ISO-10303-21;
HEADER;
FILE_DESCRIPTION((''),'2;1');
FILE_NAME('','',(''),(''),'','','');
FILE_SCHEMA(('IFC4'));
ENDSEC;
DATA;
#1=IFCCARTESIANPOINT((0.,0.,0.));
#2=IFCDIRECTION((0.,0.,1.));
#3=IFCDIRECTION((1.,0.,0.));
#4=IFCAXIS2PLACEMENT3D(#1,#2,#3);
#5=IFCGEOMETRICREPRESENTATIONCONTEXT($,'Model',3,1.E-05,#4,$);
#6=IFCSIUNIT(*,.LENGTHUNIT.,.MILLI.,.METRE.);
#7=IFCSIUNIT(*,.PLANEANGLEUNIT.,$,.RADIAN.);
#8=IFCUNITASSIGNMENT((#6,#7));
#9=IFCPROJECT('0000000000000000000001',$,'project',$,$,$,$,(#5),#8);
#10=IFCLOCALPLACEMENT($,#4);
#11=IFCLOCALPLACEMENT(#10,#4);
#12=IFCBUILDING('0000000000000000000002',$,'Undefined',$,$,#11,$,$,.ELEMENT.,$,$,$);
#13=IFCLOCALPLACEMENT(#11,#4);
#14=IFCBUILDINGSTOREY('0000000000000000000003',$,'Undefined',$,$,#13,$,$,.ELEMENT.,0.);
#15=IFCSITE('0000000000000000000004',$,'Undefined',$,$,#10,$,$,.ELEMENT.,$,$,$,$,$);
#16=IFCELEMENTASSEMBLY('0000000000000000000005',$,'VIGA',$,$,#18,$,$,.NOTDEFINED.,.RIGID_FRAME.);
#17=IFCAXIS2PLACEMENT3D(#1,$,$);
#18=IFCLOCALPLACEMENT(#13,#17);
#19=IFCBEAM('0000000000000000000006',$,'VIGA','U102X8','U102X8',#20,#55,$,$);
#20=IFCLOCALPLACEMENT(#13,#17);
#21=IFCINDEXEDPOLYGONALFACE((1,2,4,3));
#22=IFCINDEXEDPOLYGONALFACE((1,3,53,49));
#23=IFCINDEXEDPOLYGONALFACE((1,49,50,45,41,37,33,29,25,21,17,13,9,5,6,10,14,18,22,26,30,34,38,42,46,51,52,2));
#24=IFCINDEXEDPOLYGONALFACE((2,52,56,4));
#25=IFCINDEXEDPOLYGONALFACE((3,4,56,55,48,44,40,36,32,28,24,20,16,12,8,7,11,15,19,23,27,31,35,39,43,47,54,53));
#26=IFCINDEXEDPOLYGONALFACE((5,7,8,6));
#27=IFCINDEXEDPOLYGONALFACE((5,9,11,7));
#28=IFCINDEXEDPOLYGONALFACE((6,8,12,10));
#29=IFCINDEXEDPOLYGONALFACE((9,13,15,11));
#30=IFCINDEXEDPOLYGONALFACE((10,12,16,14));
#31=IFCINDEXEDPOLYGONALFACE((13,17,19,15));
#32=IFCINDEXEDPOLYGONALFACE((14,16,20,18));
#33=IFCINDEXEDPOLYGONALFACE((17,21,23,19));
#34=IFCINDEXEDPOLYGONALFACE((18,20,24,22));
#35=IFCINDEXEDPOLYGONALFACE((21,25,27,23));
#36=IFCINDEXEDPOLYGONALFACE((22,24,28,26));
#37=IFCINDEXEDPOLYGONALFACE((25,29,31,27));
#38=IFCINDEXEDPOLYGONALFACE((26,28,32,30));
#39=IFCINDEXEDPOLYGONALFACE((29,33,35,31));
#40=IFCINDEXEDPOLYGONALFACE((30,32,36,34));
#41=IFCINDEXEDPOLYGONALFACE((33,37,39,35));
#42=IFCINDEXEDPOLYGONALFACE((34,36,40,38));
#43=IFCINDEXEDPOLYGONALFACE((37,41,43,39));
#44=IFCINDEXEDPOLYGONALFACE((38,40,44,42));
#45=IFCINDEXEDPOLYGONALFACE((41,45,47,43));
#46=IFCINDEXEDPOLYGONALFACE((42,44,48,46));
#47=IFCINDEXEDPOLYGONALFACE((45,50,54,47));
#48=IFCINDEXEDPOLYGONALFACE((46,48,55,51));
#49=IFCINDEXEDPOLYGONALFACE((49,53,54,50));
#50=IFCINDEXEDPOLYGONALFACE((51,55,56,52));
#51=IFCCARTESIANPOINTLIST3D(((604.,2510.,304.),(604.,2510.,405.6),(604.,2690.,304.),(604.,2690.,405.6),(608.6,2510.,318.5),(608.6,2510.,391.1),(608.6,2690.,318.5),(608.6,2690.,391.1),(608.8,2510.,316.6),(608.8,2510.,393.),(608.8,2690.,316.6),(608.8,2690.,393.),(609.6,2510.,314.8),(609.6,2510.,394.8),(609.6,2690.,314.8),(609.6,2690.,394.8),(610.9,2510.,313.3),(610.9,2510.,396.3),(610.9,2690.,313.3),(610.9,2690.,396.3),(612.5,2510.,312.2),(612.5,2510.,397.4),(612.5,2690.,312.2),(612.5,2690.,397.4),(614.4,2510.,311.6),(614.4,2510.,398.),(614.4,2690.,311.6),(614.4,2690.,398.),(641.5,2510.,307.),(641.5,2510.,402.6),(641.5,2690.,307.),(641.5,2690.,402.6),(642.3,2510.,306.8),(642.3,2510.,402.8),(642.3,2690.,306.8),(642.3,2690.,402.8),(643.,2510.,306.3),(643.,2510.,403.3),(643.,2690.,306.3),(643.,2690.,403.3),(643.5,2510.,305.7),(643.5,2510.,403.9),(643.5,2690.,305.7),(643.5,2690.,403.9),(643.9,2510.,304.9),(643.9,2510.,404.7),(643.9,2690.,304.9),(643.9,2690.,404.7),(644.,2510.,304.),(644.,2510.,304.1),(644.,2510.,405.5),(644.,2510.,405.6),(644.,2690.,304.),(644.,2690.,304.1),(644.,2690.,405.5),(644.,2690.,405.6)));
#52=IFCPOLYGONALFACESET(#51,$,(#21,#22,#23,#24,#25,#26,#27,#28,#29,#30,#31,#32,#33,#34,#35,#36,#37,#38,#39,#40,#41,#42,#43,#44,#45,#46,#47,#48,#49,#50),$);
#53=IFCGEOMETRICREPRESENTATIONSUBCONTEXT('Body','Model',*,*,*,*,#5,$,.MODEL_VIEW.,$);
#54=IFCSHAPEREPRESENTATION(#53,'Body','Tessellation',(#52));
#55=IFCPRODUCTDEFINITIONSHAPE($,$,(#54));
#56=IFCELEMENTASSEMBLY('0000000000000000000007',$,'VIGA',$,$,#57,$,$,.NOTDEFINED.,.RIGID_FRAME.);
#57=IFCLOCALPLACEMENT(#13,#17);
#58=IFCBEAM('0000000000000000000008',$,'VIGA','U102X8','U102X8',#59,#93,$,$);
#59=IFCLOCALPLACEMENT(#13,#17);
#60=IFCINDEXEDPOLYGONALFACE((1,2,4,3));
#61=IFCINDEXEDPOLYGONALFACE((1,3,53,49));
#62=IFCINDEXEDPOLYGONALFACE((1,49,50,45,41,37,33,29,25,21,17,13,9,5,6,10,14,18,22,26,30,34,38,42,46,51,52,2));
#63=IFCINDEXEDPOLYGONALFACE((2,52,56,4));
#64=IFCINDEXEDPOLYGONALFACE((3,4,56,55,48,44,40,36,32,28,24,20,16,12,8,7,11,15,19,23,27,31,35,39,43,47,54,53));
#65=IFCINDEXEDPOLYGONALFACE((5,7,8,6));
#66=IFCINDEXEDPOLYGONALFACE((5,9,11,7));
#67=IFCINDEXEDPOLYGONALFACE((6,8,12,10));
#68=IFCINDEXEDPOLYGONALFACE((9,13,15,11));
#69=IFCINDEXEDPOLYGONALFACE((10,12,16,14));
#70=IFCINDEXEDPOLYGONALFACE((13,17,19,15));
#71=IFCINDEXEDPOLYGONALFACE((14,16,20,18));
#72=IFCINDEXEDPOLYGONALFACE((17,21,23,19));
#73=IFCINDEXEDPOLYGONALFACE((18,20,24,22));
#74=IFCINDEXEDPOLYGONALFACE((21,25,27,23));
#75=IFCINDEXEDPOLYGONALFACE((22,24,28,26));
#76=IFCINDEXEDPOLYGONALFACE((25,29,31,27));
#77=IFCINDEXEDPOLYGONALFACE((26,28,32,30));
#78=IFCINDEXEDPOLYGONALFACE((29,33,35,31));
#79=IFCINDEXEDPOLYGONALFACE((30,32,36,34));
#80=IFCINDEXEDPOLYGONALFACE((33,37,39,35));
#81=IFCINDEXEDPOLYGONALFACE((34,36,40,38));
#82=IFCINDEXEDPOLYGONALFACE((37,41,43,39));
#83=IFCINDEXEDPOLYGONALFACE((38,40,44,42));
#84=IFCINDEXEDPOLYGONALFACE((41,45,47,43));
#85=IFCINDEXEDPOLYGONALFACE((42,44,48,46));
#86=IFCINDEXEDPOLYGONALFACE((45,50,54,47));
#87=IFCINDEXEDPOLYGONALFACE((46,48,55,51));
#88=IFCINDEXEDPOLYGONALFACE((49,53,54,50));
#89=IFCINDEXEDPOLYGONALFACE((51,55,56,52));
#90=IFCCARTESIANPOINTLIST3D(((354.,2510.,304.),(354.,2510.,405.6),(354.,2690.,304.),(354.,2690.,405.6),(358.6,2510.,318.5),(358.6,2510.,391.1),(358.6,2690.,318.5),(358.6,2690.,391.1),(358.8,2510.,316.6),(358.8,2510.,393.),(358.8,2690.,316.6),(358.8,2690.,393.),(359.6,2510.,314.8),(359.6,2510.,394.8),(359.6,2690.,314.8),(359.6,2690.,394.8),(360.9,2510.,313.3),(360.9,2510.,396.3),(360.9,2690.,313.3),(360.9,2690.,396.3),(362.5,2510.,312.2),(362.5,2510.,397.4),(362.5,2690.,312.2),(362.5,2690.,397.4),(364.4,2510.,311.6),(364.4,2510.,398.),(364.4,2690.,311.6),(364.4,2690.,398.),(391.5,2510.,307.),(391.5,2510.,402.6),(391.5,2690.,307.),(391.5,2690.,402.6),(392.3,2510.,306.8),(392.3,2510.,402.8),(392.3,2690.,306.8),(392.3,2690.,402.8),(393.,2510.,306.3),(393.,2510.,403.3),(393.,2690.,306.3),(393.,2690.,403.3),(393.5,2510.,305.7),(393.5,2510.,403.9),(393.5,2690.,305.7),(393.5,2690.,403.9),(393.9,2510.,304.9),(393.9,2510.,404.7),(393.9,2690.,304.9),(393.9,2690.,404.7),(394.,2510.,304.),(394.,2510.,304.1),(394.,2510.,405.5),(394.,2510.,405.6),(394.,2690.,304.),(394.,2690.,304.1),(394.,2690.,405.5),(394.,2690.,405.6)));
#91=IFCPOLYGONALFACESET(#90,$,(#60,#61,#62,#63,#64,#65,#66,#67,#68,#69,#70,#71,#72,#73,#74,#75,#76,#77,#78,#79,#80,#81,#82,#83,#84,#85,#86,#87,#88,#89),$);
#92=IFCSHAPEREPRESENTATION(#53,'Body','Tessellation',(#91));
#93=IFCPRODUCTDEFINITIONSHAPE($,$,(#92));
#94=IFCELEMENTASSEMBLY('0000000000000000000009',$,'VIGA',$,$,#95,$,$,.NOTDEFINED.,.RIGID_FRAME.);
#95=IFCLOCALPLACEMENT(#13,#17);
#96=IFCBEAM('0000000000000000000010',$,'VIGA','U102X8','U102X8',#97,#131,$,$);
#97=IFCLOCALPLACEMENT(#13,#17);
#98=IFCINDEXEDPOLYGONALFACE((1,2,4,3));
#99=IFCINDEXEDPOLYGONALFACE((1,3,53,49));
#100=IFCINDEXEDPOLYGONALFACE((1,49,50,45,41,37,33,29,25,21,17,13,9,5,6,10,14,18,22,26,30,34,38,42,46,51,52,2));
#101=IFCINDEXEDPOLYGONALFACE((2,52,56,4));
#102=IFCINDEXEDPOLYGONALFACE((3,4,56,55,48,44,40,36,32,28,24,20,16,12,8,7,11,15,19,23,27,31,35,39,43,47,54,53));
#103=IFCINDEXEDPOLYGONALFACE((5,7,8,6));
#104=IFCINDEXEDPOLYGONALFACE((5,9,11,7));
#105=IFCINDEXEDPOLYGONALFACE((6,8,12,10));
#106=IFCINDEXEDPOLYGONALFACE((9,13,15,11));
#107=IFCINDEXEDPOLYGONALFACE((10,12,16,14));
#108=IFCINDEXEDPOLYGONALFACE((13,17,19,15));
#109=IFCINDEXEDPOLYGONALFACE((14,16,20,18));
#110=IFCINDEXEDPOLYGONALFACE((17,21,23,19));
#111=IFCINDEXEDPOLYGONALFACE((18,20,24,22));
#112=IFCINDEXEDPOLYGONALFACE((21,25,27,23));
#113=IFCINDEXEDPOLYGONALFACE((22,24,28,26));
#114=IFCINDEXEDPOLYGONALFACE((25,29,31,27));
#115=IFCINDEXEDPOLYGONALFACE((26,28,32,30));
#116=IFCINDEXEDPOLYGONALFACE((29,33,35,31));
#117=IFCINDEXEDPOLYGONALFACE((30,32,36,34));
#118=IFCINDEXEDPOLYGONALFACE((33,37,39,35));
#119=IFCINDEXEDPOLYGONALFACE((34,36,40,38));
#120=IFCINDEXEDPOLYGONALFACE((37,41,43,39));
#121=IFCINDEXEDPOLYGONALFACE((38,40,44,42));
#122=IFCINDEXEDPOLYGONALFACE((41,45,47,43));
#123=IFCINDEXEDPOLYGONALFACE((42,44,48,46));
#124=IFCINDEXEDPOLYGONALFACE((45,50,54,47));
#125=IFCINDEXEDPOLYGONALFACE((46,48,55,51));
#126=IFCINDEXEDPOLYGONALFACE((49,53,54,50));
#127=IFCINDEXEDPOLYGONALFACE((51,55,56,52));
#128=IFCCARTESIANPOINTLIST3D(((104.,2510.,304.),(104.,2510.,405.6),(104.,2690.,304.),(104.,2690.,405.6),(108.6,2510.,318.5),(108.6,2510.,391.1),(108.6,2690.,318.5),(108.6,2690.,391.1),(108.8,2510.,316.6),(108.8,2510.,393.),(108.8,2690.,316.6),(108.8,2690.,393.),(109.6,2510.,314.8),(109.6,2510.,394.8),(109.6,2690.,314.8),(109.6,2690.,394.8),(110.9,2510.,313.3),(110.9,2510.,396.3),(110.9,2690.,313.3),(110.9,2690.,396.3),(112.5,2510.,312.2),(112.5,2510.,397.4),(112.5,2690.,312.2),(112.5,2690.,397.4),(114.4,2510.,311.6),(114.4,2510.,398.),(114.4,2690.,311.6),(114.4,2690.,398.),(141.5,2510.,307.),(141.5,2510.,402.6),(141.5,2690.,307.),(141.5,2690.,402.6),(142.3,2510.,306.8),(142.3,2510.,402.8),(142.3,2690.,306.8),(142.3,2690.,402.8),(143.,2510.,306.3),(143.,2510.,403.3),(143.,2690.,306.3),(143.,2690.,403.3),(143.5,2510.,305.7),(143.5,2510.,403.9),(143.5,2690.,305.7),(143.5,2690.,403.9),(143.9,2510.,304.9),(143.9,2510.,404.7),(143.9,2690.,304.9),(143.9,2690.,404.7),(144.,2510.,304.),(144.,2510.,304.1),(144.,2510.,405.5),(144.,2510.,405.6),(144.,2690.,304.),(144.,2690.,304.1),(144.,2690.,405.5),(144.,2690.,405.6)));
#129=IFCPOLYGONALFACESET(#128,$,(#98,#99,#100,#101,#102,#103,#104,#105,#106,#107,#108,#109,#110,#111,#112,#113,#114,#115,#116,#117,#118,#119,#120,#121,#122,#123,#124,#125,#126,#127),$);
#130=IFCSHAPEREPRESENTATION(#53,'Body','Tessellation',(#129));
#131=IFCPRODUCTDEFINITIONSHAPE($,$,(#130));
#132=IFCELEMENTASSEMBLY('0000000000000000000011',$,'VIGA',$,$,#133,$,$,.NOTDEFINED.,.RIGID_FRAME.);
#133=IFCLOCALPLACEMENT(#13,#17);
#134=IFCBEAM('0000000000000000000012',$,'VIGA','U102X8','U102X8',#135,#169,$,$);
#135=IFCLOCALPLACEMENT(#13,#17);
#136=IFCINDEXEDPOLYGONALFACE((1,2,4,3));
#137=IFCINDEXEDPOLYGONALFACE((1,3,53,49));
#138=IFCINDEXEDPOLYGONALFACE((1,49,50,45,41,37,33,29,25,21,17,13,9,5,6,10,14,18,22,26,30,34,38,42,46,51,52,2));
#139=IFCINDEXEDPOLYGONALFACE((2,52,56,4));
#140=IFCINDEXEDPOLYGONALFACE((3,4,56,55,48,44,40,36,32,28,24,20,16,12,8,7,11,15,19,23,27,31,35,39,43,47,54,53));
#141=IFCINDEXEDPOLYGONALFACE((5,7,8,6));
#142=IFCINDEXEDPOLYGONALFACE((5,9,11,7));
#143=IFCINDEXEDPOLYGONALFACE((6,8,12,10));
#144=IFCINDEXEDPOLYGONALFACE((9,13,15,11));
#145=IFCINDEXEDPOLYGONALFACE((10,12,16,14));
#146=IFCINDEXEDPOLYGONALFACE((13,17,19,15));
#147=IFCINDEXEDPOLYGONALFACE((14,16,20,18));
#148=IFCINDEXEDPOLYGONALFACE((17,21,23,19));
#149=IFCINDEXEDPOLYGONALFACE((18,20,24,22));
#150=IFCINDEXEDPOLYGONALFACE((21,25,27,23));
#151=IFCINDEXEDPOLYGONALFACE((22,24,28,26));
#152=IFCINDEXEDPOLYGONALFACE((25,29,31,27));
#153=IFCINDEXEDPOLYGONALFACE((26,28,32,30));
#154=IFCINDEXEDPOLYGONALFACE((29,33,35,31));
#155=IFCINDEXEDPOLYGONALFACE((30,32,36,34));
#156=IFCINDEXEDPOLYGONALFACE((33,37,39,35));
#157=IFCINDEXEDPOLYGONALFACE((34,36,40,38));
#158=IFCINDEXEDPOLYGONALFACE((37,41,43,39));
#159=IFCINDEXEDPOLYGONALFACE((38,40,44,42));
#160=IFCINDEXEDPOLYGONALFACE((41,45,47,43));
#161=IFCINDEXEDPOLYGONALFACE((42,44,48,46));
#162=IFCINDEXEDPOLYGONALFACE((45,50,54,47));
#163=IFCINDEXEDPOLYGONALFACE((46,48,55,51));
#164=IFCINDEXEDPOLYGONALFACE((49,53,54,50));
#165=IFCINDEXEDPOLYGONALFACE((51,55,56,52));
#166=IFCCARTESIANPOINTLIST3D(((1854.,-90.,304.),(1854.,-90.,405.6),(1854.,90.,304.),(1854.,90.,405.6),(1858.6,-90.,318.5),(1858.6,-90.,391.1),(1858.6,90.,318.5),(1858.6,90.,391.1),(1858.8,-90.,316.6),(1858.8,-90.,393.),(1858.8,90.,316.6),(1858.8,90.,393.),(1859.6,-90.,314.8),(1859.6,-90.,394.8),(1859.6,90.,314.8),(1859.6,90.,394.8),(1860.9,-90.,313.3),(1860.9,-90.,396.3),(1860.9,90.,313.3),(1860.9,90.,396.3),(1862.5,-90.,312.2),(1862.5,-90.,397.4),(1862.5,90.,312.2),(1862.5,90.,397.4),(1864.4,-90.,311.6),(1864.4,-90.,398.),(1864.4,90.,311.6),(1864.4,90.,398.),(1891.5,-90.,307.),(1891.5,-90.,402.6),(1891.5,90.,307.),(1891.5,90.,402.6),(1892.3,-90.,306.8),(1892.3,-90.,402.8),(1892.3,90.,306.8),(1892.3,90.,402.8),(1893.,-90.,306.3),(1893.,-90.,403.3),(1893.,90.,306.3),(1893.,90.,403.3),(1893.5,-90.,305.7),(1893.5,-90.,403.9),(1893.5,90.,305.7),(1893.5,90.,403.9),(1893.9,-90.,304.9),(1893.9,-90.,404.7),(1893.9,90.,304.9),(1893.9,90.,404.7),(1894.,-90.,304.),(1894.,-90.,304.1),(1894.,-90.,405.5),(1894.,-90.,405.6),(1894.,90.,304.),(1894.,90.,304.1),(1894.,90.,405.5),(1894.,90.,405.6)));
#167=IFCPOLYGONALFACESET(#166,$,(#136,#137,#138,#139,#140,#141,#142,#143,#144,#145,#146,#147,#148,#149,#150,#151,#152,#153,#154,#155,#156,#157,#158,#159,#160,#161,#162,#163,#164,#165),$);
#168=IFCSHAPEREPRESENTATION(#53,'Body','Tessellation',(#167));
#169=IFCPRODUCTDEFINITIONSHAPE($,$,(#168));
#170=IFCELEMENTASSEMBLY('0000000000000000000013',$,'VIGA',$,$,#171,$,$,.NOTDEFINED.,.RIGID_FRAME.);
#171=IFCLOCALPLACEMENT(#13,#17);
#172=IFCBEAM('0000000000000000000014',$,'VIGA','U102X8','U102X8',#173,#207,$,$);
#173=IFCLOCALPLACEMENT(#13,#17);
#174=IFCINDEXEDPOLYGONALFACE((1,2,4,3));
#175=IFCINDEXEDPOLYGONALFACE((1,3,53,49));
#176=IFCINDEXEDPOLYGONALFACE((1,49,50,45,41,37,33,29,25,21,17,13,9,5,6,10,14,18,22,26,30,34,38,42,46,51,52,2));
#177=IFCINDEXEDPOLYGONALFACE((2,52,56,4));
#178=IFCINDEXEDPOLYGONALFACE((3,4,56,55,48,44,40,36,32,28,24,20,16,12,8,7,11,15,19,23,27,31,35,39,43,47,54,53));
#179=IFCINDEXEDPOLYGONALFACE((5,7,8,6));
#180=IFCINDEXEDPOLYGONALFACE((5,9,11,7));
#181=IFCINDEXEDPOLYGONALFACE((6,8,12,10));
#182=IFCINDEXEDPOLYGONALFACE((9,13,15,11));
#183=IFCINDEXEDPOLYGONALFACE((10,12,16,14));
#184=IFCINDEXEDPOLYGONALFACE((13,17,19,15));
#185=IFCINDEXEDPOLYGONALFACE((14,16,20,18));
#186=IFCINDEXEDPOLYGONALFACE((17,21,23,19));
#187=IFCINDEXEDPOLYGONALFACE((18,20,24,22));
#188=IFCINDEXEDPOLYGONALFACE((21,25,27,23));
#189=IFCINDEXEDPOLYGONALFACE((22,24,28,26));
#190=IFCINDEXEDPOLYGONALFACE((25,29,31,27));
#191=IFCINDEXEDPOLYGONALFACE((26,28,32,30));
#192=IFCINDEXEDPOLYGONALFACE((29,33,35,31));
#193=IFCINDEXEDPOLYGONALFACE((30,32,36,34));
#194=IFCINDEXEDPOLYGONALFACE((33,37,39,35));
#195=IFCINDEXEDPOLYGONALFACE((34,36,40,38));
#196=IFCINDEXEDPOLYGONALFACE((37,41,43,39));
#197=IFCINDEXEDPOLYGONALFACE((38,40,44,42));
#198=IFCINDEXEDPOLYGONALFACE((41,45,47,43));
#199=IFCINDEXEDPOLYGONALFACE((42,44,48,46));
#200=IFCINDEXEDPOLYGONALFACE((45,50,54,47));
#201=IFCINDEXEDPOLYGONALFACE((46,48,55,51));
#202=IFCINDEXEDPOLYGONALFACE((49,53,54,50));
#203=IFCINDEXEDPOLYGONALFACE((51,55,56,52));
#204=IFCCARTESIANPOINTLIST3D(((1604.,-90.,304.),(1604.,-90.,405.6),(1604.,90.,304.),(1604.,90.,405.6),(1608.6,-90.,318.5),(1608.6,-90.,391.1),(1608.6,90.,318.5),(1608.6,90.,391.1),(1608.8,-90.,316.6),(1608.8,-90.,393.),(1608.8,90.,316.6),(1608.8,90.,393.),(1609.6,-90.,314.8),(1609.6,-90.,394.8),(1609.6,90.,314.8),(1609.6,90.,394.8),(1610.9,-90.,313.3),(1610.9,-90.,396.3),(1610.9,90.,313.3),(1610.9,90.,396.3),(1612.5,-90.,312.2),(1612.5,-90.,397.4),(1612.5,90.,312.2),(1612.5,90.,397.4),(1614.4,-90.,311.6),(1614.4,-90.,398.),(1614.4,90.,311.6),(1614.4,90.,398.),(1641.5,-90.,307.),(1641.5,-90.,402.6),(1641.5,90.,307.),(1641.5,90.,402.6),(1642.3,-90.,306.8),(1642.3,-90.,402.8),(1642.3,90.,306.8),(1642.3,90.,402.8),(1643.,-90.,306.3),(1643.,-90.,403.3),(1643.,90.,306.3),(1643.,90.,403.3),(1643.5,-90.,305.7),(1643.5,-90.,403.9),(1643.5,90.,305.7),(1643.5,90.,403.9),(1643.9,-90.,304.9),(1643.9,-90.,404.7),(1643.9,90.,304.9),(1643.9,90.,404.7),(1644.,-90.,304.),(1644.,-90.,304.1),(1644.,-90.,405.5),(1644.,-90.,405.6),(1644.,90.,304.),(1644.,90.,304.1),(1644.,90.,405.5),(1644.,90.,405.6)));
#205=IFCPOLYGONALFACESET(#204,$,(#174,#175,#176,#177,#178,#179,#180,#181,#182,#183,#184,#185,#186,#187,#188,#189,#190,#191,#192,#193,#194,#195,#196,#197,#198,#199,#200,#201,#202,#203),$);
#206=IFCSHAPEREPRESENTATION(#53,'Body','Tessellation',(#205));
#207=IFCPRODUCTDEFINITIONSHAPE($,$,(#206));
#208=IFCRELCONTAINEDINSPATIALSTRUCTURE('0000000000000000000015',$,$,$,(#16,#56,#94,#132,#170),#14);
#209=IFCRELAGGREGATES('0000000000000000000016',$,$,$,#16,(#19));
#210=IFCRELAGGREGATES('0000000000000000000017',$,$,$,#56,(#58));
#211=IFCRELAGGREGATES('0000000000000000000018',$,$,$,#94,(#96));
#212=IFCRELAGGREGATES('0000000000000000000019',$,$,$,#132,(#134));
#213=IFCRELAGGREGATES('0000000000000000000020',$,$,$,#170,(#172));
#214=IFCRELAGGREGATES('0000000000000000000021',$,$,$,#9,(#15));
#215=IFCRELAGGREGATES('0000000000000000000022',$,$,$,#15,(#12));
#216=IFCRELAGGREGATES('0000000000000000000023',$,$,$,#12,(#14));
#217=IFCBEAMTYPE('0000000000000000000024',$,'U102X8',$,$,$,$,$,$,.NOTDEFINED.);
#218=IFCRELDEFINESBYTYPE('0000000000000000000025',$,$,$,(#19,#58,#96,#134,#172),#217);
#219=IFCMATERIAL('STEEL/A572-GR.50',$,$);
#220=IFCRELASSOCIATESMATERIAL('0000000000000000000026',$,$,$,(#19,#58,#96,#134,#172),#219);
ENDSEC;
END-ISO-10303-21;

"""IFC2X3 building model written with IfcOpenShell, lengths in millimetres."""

from ifc_helpers import new_model, si_unit, frame, origin_with_axes, origin_2d_with_axis, place, context, subcontext, project, spatial, u_section, extrude, material, type_object, element, aggregate, save


model = new_model("IFC2X3")

# Units and contexts
model_context = context("Model", 3, precision=1e-05, world=origin_with_axes())
body_context = subcontext(model_context, "Body", "Model", "MODEL_VIEW")
ifc_project = project(units=[si_unit("LENGTHUNIT", "METRE", prefix="MILLI"), si_unit("PLANEANGLEUNIT", "RADIAN")], contexts=[model_context])

# Site, building, storey
site_placement = place(None, origin_with_axes())
site = spatial("IfcSite", under=ifc_project, at=site_placement, Name="Undefined", CompositionType="ELEMENT")
building_placement = place(site_placement, origin_with_axes())
building = spatial("IfcBuilding", under=site, at=building_placement, Name="Undefined", CompositionType="ELEMENT")
storey_placement = place(building_placement, origin_with_axes())
storey = spatial("IfcBuildingStorey", under=building, at=storey_placement, Name="Undefined", CompositionType="ELEMENT", Elevation=0.0)

# Element assemblies, beams
ifc_material_1 = material(Name="STEEL/A572-GR.50")
beam_type_1 = type_object("IfcBeamType", Name="U102X8", PredefinedType="NOTDEFINED")
assembly_1_placement = place(storey_placement, origin_with_axes())
assembly_1 = element("IfcElementAssembly", 1, at=assembly_1_placement, inside=storey, Name="VIGA", AssemblyPlace="NOTDEFINED", PredefinedType="RIGID_FRAME")
beam_1_placement = place(assembly_1_placement, frame((624.0, 2510.0, 354.8), z_axis=(0.0, 0.0, 1.0), x_axis=(0.0, 1.0, 0.0)))
beam_1 = element("IfcBeam", 2, at=beam_1_placement, type_object=beam_type_1, material=ifc_material_1, Name="VIGA", Description="U102X8", ObjectType="U102X8", context=body_context, shape_type="SweptSolid", body=[
    extrude(u_section(Depth=101.6, FlangeWidth=40.0, WebThickness=4.6, FlangeThickness=6.0, FilletRadius=7.0, EdgeRadius=3.0, FlangeSlope=0.16839, at=origin_2d_with_axis()), frame((180.0, 0.0, 0.0), z_axis=(-1.0, 0.0, 0.0), x_axis=(0.0, -1.0, 0.0)), (0.0, 0.0, 1.0), 180.0),
])
aggregate(assembly_1, [beam_1])
assembly_2_placement = place(storey_placement, origin_with_axes())
assembly_2 = element("IfcElementAssembly", 3, at=assembly_2_placement, inside=storey, Name="VIGA", AssemblyPlace="NOTDEFINED", PredefinedType="RIGID_FRAME")
beam_2_placement = place(assembly_2_placement, frame((374.0, 2510.0, 354.8), z_axis=(0.0, 0.0, 1.0), x_axis=(0.0, 1.0, 0.0)))
beam_2 = element("IfcBeam", 4, at=beam_2_placement, type_object=beam_type_1, material=ifc_material_1, Name="VIGA", Description="U102X8", ObjectType="U102X8", context=body_context, shape_type="SweptSolid", body=[
    extrude(u_section(Depth=101.6, FlangeWidth=40.0, WebThickness=4.6, FlangeThickness=6.0, FilletRadius=7.0, EdgeRadius=3.0, FlangeSlope=0.16839, at=origin_2d_with_axis()), frame((180.0, 0.0, 0.0), z_axis=(-1.0, 0.0, 0.0), x_axis=(0.0, -1.0, 0.0)), (0.0, 0.0, 1.0), 180.0),
])
aggregate(assembly_2, [beam_2])
assembly_3_placement = place(storey_placement, origin_with_axes())
assembly_3 = element("IfcElementAssembly", 5, at=assembly_3_placement, inside=storey, Name="VIGA", AssemblyPlace="NOTDEFINED", PredefinedType="RIGID_FRAME")
beam_3_placement = place(assembly_3_placement, frame((124.0, 2510.0, 354.8), z_axis=(0.0, 0.0, 1.0), x_axis=(0.0, 1.0, 0.0)))
beam_3 = element("IfcBeam", 6, at=beam_3_placement, type_object=beam_type_1, material=ifc_material_1, Name="VIGA", Description="U102X8", ObjectType="U102X8", context=body_context, shape_type="SweptSolid", body=[
    extrude(u_section(Depth=101.6, FlangeWidth=40.0, WebThickness=4.6, FlangeThickness=6.0, FilletRadius=7.0, EdgeRadius=3.0, FlangeSlope=0.16839, at=origin_2d_with_axis()), frame((180.0, 0.0, 0.0), z_axis=(-1.0, 0.0, 0.0), x_axis=(0.0, -1.0, 0.0)), (0.0, 0.0, 1.0), 180.0),
])
aggregate(assembly_3, [beam_3])
assembly_4_placement = place(storey_placement, origin_with_axes())
assembly_4 = element("IfcElementAssembly", 7, at=assembly_4_placement, inside=storey, Name="VIGA", AssemblyPlace="NOTDEFINED", PredefinedType="RIGID_FRAME")
beam_4_placement = place(assembly_4_placement, frame((1874.0, -90.0, 354.8), z_axis=(0.0, 0.0, 1.0), x_axis=(0.0, 1.0, 0.0)))
beam_4 = element("IfcBeam", 8, at=beam_4_placement, type_object=beam_type_1, material=ifc_material_1, Name="VIGA", Description="U102X8", ObjectType="U102X8", context=body_context, shape_type="SweptSolid", body=[
    extrude(u_section(Depth=101.6, FlangeWidth=40.0, WebThickness=4.6, FlangeThickness=6.0, FilletRadius=7.0, EdgeRadius=3.0, FlangeSlope=0.16839, at=origin_2d_with_axis()), frame((180.0, 0.0, 0.0), z_axis=(-1.0, 0.0, 0.0), x_axis=(0.0, -1.0, 0.0)), (0.0, 0.0, 1.0), 180.0),
])
aggregate(assembly_4, [beam_4])
assembly_5_placement = place(storey_placement, origin_with_axes())
assembly_5 = element("IfcElementAssembly", 9, at=assembly_5_placement, inside=storey, Name="VIGA", AssemblyPlace="NOTDEFINED", PredefinedType="RIGID_FRAME")
beam_5_placement = place(assembly_5_placement, frame((1624.0, -90.0, 354.8), z_axis=(0.0, 0.0, 1.0), x_axis=(0.0, 1.0, 0.0)))
beam_5 = element("IfcBeam", 10, at=beam_5_placement, type_object=beam_type_1, material=ifc_material_1, Name="VIGA", Description="U102X8", ObjectType="U102X8", context=body_context, shape_type="SweptSolid", body=[
    extrude(u_section(Depth=101.6, FlangeWidth=40.0, WebThickness=4.6, FlangeThickness=6.0, FilletRadius=7.0, EdgeRadius=3.0, FlangeSlope=0.16839, at=origin_2d_with_axis()), frame((180.0, 0.0, 0.0), z_axis=(-1.0, 0.0, 0.0), x_axis=(0.0, -1.0, 0.0)), (0.0, 0.0, 1.0), 180.0),
])
aggregate(assembly_5, [beam_5])

save(model, "model.ifc")
